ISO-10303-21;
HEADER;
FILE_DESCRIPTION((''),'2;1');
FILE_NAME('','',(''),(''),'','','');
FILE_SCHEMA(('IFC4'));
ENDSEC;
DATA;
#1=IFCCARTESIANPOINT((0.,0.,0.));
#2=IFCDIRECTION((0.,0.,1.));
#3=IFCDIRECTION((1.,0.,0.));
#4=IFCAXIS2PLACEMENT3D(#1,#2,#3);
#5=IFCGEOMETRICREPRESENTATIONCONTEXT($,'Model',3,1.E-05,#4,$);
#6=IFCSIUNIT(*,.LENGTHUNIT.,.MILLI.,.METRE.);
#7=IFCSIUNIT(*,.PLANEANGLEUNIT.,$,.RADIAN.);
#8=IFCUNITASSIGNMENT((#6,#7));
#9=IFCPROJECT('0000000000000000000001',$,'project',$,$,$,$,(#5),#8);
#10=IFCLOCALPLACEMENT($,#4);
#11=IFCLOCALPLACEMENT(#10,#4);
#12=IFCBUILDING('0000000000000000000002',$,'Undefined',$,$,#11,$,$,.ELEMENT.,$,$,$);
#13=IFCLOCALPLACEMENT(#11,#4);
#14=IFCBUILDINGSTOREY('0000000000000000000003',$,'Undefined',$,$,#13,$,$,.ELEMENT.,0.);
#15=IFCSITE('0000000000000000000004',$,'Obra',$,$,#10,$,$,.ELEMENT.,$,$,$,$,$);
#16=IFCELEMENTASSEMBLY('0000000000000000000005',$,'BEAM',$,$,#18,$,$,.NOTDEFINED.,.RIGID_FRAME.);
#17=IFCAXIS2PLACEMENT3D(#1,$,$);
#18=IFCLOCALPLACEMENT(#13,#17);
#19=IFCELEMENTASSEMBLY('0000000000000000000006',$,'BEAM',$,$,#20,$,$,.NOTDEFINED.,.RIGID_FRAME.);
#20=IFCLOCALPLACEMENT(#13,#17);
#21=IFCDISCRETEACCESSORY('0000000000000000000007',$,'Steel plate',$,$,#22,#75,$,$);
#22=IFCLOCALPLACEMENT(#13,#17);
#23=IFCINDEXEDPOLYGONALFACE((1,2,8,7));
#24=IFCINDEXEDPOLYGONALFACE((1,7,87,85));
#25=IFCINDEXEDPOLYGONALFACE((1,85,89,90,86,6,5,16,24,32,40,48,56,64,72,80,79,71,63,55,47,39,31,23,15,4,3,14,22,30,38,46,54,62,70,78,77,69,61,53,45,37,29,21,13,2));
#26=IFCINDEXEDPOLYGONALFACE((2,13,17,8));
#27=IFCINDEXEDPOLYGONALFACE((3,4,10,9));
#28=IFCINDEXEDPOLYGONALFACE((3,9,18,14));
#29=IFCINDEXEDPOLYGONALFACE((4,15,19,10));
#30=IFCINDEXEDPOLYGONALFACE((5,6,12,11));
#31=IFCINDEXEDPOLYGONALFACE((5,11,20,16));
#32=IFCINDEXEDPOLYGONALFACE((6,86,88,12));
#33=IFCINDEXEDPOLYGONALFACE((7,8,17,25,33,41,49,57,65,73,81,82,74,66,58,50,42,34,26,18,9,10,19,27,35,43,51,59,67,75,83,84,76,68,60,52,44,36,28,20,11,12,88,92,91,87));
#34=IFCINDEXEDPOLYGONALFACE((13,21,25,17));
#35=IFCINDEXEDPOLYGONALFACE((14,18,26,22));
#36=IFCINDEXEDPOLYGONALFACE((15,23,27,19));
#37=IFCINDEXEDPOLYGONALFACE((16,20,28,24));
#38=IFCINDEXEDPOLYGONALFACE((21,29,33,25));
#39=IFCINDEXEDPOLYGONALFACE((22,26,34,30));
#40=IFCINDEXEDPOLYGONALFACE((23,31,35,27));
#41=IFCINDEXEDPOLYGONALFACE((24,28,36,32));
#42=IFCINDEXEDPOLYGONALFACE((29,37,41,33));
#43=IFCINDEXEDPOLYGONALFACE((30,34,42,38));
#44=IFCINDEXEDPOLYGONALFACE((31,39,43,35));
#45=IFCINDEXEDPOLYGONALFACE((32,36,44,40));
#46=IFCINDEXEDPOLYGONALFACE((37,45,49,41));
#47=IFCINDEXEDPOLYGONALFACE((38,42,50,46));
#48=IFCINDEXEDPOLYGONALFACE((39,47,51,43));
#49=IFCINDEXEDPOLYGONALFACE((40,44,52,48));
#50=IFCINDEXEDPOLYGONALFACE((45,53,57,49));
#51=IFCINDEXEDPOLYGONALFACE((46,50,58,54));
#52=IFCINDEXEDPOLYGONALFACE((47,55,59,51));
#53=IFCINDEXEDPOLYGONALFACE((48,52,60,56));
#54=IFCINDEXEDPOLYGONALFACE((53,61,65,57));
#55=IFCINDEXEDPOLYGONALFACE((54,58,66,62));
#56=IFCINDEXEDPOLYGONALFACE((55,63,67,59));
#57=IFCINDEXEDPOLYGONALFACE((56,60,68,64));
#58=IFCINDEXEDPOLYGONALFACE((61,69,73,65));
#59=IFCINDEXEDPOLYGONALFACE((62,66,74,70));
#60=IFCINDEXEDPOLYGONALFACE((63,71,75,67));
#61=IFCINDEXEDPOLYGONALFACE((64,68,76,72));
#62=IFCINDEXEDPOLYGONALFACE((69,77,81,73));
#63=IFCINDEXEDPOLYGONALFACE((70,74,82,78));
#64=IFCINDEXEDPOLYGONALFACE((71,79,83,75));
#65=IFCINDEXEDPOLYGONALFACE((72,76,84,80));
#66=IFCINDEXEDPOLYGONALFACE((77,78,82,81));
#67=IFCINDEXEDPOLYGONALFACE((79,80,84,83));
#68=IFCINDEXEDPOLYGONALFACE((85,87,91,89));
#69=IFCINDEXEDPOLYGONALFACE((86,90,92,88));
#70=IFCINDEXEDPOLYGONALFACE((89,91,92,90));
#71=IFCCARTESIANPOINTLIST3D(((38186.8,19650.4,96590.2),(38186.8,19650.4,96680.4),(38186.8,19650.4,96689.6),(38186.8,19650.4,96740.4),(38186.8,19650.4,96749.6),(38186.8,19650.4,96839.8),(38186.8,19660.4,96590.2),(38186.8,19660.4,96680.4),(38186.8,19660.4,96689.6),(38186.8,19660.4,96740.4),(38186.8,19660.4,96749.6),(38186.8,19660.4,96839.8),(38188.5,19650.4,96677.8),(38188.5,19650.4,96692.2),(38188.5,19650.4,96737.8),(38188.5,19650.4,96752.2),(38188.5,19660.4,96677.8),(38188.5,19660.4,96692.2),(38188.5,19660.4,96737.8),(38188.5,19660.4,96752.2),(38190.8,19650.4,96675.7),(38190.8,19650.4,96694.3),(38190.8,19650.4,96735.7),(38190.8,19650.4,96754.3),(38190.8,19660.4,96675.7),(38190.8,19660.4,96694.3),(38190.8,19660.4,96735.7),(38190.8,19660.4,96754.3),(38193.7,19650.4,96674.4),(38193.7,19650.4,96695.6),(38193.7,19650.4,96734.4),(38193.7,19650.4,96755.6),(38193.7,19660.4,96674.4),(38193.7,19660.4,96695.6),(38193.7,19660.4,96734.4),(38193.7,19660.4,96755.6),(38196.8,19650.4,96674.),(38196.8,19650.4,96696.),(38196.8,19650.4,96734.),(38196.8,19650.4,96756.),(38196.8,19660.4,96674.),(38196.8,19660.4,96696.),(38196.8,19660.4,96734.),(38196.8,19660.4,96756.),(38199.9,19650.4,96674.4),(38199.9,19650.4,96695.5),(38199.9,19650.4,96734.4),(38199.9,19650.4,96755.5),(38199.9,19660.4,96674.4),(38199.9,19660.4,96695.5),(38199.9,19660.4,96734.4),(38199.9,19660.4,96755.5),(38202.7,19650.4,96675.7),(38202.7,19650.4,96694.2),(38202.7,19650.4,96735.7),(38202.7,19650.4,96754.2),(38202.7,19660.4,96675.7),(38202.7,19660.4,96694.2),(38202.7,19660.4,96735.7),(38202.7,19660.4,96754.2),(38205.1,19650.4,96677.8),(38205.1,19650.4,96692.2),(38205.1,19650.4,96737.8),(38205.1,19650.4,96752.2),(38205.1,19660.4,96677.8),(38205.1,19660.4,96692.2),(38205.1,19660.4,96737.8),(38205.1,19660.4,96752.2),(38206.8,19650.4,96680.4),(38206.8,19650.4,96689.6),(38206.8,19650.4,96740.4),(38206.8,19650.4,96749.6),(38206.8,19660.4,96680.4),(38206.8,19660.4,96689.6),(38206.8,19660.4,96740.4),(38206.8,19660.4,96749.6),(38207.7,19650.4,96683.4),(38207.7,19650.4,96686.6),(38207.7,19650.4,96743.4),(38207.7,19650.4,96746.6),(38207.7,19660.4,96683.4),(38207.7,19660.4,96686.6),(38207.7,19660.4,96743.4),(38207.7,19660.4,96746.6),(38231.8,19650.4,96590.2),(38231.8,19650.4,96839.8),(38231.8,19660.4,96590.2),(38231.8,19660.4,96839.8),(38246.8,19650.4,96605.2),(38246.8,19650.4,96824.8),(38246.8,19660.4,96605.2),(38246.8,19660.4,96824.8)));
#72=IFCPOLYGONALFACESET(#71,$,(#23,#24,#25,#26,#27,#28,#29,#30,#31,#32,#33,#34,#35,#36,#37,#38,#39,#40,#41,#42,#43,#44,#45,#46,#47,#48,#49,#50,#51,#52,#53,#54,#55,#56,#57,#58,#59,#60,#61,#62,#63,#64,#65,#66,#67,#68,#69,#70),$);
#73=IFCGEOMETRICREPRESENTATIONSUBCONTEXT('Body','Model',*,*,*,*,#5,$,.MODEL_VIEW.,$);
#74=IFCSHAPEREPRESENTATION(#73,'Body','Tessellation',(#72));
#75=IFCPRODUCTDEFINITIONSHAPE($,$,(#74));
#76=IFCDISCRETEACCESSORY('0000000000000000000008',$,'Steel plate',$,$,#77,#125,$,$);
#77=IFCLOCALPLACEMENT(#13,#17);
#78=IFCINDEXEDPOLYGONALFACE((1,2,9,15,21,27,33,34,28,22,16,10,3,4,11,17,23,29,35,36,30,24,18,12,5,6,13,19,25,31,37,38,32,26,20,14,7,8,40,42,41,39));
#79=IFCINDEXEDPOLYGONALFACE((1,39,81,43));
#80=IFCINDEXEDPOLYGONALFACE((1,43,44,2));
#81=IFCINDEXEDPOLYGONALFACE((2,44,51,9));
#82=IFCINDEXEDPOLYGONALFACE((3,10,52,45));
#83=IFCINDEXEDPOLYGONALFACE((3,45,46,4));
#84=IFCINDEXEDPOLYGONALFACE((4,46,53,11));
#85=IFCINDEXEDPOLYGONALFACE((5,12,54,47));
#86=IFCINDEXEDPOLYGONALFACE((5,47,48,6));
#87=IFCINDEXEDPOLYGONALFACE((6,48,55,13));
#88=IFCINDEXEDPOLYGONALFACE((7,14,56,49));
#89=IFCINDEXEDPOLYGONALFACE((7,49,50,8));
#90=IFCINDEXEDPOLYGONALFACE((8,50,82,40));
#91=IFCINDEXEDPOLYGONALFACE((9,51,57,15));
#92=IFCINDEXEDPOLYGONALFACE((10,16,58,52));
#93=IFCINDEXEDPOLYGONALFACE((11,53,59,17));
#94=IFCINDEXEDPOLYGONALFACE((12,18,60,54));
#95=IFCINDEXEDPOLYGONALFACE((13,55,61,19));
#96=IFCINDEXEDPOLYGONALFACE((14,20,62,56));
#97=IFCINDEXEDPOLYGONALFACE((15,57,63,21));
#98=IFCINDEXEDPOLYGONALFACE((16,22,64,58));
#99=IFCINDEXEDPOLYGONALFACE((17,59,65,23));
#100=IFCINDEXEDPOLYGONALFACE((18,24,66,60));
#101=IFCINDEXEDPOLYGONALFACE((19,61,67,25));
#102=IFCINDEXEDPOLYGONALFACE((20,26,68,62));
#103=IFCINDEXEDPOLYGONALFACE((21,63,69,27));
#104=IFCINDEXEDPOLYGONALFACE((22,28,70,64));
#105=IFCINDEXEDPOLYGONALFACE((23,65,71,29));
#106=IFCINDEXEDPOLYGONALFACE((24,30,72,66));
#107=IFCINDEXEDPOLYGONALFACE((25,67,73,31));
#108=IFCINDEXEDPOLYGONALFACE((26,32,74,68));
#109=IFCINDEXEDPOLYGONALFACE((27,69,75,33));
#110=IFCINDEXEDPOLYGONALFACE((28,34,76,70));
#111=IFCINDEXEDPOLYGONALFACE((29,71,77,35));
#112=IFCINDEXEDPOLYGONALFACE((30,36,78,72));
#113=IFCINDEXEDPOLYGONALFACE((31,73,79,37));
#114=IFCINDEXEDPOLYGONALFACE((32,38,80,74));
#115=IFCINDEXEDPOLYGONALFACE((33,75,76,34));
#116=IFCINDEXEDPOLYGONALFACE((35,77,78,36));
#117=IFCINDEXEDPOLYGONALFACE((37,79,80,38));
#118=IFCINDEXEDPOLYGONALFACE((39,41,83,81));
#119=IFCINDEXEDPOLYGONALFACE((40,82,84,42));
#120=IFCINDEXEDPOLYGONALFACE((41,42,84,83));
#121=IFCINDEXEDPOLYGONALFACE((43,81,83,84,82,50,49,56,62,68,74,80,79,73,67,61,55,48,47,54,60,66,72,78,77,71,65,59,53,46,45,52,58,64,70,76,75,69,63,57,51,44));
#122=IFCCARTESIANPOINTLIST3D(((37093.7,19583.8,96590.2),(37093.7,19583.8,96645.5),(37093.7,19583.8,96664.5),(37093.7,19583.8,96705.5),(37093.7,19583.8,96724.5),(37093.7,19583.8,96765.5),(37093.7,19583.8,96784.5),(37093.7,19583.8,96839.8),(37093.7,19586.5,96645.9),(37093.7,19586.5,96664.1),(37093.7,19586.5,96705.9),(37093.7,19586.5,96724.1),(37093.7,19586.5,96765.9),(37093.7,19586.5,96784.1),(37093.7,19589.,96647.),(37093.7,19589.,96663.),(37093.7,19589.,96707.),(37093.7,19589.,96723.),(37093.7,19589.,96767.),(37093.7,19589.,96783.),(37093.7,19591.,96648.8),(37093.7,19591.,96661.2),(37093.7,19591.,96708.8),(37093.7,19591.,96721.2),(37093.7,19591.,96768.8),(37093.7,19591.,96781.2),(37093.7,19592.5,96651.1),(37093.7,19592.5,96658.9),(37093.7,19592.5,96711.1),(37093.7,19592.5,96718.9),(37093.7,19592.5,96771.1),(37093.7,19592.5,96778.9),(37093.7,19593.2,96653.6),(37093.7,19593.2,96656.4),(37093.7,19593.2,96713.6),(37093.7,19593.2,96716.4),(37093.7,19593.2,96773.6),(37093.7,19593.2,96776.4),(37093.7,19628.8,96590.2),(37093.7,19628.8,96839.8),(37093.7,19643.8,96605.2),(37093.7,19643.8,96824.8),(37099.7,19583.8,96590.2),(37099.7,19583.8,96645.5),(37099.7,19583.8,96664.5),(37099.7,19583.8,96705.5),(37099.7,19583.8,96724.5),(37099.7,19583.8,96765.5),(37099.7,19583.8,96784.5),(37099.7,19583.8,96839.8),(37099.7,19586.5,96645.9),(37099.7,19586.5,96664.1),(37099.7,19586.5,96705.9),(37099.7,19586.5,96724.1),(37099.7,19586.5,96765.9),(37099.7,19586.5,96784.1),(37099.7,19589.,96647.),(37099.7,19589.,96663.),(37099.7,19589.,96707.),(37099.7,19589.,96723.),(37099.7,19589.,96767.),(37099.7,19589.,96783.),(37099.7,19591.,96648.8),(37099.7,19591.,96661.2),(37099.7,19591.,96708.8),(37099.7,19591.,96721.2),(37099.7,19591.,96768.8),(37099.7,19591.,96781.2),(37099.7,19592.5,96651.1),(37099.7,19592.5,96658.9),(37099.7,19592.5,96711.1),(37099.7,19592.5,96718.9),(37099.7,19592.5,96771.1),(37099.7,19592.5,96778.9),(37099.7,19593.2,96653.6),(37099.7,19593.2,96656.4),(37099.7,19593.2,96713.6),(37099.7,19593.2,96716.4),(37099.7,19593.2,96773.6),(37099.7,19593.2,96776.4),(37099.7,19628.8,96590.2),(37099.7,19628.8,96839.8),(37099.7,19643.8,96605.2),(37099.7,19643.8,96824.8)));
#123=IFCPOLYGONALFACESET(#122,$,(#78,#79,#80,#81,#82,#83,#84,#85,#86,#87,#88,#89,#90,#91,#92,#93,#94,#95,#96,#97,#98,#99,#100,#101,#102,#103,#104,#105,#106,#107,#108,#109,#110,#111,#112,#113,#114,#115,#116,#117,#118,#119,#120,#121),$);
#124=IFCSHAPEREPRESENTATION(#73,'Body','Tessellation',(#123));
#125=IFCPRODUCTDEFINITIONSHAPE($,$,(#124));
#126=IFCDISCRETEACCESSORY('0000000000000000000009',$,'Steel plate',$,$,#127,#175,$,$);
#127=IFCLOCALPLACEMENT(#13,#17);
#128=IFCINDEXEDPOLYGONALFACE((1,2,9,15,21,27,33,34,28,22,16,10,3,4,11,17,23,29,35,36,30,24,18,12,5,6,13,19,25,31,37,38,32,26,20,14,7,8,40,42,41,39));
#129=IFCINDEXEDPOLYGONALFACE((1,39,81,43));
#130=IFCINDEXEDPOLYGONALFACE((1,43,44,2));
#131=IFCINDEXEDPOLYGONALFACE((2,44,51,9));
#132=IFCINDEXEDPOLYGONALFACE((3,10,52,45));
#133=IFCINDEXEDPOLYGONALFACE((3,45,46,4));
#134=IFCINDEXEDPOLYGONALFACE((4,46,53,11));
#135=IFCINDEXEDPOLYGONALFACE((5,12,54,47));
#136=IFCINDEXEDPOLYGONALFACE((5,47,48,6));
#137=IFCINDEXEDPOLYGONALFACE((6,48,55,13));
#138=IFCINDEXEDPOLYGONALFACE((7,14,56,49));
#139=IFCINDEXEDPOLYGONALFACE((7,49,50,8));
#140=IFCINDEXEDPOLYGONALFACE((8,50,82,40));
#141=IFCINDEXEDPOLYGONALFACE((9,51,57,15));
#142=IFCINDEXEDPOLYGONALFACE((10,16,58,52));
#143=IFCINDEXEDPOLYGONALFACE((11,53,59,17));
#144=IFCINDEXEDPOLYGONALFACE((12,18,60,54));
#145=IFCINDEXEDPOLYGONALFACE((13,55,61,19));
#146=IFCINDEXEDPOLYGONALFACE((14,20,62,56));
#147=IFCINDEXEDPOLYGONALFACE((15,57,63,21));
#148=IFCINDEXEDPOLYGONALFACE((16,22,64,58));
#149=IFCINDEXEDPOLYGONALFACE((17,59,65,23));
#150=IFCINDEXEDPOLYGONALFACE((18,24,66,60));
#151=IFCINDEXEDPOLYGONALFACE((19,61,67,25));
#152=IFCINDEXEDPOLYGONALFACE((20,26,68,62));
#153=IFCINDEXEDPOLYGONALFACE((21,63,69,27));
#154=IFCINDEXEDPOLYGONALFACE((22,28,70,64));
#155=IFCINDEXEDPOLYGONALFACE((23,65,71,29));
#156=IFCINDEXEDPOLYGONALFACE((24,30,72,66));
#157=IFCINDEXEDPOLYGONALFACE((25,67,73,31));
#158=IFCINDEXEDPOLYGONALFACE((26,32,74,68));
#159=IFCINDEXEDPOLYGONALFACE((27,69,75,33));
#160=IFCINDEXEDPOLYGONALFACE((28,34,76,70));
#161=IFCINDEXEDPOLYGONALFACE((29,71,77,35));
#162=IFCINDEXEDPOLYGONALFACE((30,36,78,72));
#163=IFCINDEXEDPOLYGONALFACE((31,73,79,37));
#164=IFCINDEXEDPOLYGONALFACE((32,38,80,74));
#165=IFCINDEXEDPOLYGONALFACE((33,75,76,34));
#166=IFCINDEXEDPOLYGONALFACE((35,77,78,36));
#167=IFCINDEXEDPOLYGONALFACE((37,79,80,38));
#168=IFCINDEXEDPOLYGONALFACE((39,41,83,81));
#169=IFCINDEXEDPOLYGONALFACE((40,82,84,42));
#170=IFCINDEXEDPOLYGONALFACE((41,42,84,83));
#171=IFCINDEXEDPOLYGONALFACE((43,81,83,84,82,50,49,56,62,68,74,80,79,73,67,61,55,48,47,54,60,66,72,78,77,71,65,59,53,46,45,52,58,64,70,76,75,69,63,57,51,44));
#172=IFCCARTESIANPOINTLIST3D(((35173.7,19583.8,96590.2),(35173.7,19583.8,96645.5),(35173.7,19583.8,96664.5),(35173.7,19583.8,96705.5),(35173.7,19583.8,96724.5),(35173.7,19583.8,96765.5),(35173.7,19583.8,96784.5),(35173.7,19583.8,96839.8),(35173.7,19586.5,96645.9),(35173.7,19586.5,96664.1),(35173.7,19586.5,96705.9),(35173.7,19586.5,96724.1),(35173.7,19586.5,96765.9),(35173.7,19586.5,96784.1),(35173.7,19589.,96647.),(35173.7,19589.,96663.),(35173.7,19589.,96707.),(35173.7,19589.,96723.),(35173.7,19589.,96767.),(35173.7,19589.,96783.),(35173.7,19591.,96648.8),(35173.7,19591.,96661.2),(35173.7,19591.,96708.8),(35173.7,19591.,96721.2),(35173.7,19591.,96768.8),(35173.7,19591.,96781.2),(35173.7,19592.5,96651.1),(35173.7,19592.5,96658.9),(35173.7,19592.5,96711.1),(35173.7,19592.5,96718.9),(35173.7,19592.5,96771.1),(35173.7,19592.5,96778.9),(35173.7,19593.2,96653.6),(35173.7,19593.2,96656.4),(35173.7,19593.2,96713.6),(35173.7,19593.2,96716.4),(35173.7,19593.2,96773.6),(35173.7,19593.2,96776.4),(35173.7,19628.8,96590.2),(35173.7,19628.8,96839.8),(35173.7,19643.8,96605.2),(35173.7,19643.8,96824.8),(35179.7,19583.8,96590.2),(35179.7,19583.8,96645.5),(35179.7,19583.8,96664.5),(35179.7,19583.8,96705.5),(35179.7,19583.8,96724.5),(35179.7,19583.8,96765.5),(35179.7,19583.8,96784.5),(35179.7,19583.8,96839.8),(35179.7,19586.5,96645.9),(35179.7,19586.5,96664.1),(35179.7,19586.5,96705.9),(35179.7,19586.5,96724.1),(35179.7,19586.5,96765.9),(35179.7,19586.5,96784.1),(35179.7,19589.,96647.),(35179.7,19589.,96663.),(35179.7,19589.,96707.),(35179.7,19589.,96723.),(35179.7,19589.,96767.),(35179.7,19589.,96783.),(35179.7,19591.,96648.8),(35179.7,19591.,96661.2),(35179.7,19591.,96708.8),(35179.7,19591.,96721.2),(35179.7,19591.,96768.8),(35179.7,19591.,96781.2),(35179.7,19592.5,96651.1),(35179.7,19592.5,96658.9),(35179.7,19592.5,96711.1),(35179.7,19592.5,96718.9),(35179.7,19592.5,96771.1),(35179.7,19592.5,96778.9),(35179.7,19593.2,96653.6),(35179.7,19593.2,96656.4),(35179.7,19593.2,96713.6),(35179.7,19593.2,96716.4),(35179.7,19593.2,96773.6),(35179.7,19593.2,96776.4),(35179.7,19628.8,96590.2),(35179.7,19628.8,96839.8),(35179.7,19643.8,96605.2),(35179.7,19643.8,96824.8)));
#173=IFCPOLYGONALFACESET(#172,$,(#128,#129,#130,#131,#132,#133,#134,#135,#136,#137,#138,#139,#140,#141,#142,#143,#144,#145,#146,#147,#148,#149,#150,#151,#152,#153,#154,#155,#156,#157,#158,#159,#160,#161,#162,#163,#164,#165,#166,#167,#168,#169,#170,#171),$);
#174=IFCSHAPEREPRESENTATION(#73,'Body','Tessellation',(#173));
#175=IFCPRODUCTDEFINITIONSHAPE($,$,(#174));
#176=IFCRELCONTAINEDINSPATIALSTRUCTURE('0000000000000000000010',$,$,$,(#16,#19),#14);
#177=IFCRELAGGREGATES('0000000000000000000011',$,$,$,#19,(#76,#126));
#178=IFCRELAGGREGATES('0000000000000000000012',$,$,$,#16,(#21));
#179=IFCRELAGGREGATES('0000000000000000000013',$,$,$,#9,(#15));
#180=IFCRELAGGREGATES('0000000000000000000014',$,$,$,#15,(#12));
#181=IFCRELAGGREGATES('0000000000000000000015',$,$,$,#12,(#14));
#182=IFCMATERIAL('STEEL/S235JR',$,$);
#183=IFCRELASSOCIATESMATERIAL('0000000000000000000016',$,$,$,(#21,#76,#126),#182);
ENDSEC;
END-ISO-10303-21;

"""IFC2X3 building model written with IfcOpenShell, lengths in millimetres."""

from ifc_helpers import new_model, si_unit, frame, origin_with_axes, origin_2d_with_axis, place, context, subcontext, project, spatial, polyline, circle, outline, extrude, source, transform, mapped, material, element, aggregate, save


model = new_model("IFC2X3")

# Units and contexts
model_context = context("Model", 3, precision=1e-05, world=origin_with_axes())
body_context = subcontext(model_context, "Body", "Model", "MODEL_VIEW")
ifc_project = project(units=[si_unit("LENGTHUNIT", "METRE", prefix="MILLI"), si_unit("PLANEANGLEUNIT", "RADIAN")], contexts=[model_context])

# Site, building, storey
site_placement = place(None, origin_with_axes())
site = spatial("IfcSite", under=ifc_project, at=site_placement, Name="Obra", CompositionType="ELEMENT")
building_placement = place(site_placement, origin_with_axes())
building = spatial("IfcBuilding", under=site, at=building_placement, Name="Undefined", CompositionType="ELEMENT")
storey_placement = place(building_placement, origin_with_axes())
storey = spatial("IfcBuildingStorey", under=building, at=storey_placement, Name="Undefined", CompositionType="ELEMENT", Elevation=0.0)

# Shared definitions
ifc_material = material(Name="STEEL/S235JR")

# Element assembly
assembly_1_placement = place(storey_placement, origin_with_axes())
assembly_1 = element("IfcElementAssembly", 1, at=assembly_1_placement, inside=storey, Name="BEAM", AssemblyPlace="NOTDEFINED", PredefinedType="RIGID_FRAME")

# Element assembly
assembly_2_placement = place(storey_placement, origin_with_axes())
assembly_2 = element("IfcElementAssembly", 2, at=assembly_2_placement, inside=storey, Name="BEAM", AssemblyPlace="NOTDEFINED", PredefinedType="RIGID_FRAME")
shared_shape_1 = source(origin_with_axes(), body_context, "Body", "SweptSolid", [
    extrude(circle(Radius=9.5, at=origin_2d_with_axis()), frame((0.0, -9.4, 0.0), z_axis=(0.0, 1.0, 0.0), x_axis=(1.0, 0.0, 0.0)), (0.0, 0.0, 1.0), 6.2),
])

# Discrete accessories, openings
discrete_accessory_1_placement = place(assembly_1_placement, frame((38186.8, 19655.4, 96590.2), z_axis=(0.0, -1.0, 0.0), x_axis=(1.0, 0.0, 0.0)))
discrete_accessory_1 = element("IfcDiscreteAccessory", 3, at=discrete_accessory_1_placement, material=ifc_material, Name="Steel plate", context=body_context, shape_type="SweptSolid", body=[
    extrude(outline(polyline([(0.0, 0.0), (45.0, 0.0), (60.0, 15.0), (60.0, 234.6), (45.0, 249.6), (0.0, 249.6), (0.0, 0.0)])), frame((0.0, 0.0, -5.0), z_axis=(0.0, 0.0, 1.0), x_axis=(1.0, 0.0, 0.0)), (0.0, 0.0, 1.0), 10.0),
])
shared_shape_2 = source(origin_with_axes(), body_context, "Body", "SweptSolid", [
    extrude(circle(Radius=11.0, at=origin_2d_with_axis()), frame((0.0, -13.4, 0.0), z_axis=(0.0, 1.0, 0.0), x_axis=(1.0, 0.0, 0.0)), (0.0, 0.0, 1.0), 10.2),
])
opening_1_placement = place(assembly_1_placement, frame((38236.8, 19647.1, 96850.0), z_axis=(-1.0, 0.0, 0.0), x_axis=(0.0, 0.0, -1.0)))
element("IfcOpeningElement", 4, at=opening_1_placement, cuts=discrete_accessory_1, ObjectType="Opening", context=body_context, shape_type="MappedRepresentation", body=[
    mapped(shared_shape_2, transform((105.0, 0.0, 40.0))),
    mapped(shared_shape_2, transform((165.0, 0.0, 40.0))),
])
discrete_accessory_2_placement = place(assembly_2_placement, frame((37096.7, 19583.8, 96590.2), z_axis=(1.0, 0.0, 0.0), x_axis=(0.0, 1.0, 0.0)))
discrete_accessory_2 = element("IfcDiscreteAccessory", 5, at=discrete_accessory_2_placement, material=ifc_material, Name="Steel plate", context=body_context, shape_type="SweptSolid", body=[
    extrude(outline(polyline([(0.0, 0.0), (45.0, 0.0), (60.0, 15.0), (60.0, 234.6), (45.0, 249.6), (0.0, 249.6), (0.0, 0.0)])), frame((0.0, 0.0, -3.0), z_axis=(0.0, 0.0, 1.0), x_axis=(1.0, 0.0, 0.0)), (0.0, 0.0, 1.0), 6.0),
])
opening_2_placement = place(assembly_2_placement, frame((37103.0, 19633.8, 96850.0), z_axis=(0.0, -1.0, 0.0), x_axis=(0.0, 0.0, -1.0)))
element("IfcOpeningElement", 6, at=opening_2_placement, cuts=discrete_accessory_2, ObjectType="Opening", context=body_context, shape_type="MappedRepresentation", body=[
    mapped(shared_shape_1, transform((75.0, 0.0, 50.0))),
    mapped(shared_shape_1, transform((135.0, 0.0, 50.0))),
    mapped(shared_shape_1, transform((195.0, 0.0, 50.0))),
])
discrete_accessory_3_placement = place(assembly_2_placement, frame((35176.7, 19583.8, 96590.2), z_axis=(1.0, 0.0, 0.0), x_axis=(0.0, 1.0, 0.0)))
discrete_accessory_3 = element("IfcDiscreteAccessory", 7, at=discrete_accessory_3_placement, material=ifc_material, Name="Steel plate", context=body_context, shape_type="SweptSolid", body=[
    extrude(outline(polyline([(0.0, 0.0), (45.0, 0.0), (60.0, 15.0), (60.0, 234.6), (45.0, 249.6), (0.0, 249.6), (0.0, 0.0)])), frame((0.0, 0.0, -3.0), z_axis=(0.0, 0.0, 1.0), x_axis=(1.0, 0.0, 0.0)), (0.0, 0.0, 1.0), 6.0),
])
opening_3_placement = place(assembly_2_placement, frame((35183.0, 19633.8, 96850.0), z_axis=(0.0, -1.0, 0.0), x_axis=(0.0, 0.0, -1.0)))
element("IfcOpeningElement", 8, at=opening_3_placement, cuts=discrete_accessory_3, ObjectType="Opening", context=body_context, shape_type="MappedRepresentation", body=[
    mapped(shared_shape_1, transform((75.0, 0.0, 50.0))),
    mapped(shared_shape_1, transform((135.0, 0.0, 50.0))),
    mapped(shared_shape_1, transform((195.0, 0.0, 50.0))),
])
aggregate(assembly_2, [discrete_accessory_2, discrete_accessory_3])
aggregate(assembly_1, [discrete_accessory_1])

save(model, "model.ifc")
